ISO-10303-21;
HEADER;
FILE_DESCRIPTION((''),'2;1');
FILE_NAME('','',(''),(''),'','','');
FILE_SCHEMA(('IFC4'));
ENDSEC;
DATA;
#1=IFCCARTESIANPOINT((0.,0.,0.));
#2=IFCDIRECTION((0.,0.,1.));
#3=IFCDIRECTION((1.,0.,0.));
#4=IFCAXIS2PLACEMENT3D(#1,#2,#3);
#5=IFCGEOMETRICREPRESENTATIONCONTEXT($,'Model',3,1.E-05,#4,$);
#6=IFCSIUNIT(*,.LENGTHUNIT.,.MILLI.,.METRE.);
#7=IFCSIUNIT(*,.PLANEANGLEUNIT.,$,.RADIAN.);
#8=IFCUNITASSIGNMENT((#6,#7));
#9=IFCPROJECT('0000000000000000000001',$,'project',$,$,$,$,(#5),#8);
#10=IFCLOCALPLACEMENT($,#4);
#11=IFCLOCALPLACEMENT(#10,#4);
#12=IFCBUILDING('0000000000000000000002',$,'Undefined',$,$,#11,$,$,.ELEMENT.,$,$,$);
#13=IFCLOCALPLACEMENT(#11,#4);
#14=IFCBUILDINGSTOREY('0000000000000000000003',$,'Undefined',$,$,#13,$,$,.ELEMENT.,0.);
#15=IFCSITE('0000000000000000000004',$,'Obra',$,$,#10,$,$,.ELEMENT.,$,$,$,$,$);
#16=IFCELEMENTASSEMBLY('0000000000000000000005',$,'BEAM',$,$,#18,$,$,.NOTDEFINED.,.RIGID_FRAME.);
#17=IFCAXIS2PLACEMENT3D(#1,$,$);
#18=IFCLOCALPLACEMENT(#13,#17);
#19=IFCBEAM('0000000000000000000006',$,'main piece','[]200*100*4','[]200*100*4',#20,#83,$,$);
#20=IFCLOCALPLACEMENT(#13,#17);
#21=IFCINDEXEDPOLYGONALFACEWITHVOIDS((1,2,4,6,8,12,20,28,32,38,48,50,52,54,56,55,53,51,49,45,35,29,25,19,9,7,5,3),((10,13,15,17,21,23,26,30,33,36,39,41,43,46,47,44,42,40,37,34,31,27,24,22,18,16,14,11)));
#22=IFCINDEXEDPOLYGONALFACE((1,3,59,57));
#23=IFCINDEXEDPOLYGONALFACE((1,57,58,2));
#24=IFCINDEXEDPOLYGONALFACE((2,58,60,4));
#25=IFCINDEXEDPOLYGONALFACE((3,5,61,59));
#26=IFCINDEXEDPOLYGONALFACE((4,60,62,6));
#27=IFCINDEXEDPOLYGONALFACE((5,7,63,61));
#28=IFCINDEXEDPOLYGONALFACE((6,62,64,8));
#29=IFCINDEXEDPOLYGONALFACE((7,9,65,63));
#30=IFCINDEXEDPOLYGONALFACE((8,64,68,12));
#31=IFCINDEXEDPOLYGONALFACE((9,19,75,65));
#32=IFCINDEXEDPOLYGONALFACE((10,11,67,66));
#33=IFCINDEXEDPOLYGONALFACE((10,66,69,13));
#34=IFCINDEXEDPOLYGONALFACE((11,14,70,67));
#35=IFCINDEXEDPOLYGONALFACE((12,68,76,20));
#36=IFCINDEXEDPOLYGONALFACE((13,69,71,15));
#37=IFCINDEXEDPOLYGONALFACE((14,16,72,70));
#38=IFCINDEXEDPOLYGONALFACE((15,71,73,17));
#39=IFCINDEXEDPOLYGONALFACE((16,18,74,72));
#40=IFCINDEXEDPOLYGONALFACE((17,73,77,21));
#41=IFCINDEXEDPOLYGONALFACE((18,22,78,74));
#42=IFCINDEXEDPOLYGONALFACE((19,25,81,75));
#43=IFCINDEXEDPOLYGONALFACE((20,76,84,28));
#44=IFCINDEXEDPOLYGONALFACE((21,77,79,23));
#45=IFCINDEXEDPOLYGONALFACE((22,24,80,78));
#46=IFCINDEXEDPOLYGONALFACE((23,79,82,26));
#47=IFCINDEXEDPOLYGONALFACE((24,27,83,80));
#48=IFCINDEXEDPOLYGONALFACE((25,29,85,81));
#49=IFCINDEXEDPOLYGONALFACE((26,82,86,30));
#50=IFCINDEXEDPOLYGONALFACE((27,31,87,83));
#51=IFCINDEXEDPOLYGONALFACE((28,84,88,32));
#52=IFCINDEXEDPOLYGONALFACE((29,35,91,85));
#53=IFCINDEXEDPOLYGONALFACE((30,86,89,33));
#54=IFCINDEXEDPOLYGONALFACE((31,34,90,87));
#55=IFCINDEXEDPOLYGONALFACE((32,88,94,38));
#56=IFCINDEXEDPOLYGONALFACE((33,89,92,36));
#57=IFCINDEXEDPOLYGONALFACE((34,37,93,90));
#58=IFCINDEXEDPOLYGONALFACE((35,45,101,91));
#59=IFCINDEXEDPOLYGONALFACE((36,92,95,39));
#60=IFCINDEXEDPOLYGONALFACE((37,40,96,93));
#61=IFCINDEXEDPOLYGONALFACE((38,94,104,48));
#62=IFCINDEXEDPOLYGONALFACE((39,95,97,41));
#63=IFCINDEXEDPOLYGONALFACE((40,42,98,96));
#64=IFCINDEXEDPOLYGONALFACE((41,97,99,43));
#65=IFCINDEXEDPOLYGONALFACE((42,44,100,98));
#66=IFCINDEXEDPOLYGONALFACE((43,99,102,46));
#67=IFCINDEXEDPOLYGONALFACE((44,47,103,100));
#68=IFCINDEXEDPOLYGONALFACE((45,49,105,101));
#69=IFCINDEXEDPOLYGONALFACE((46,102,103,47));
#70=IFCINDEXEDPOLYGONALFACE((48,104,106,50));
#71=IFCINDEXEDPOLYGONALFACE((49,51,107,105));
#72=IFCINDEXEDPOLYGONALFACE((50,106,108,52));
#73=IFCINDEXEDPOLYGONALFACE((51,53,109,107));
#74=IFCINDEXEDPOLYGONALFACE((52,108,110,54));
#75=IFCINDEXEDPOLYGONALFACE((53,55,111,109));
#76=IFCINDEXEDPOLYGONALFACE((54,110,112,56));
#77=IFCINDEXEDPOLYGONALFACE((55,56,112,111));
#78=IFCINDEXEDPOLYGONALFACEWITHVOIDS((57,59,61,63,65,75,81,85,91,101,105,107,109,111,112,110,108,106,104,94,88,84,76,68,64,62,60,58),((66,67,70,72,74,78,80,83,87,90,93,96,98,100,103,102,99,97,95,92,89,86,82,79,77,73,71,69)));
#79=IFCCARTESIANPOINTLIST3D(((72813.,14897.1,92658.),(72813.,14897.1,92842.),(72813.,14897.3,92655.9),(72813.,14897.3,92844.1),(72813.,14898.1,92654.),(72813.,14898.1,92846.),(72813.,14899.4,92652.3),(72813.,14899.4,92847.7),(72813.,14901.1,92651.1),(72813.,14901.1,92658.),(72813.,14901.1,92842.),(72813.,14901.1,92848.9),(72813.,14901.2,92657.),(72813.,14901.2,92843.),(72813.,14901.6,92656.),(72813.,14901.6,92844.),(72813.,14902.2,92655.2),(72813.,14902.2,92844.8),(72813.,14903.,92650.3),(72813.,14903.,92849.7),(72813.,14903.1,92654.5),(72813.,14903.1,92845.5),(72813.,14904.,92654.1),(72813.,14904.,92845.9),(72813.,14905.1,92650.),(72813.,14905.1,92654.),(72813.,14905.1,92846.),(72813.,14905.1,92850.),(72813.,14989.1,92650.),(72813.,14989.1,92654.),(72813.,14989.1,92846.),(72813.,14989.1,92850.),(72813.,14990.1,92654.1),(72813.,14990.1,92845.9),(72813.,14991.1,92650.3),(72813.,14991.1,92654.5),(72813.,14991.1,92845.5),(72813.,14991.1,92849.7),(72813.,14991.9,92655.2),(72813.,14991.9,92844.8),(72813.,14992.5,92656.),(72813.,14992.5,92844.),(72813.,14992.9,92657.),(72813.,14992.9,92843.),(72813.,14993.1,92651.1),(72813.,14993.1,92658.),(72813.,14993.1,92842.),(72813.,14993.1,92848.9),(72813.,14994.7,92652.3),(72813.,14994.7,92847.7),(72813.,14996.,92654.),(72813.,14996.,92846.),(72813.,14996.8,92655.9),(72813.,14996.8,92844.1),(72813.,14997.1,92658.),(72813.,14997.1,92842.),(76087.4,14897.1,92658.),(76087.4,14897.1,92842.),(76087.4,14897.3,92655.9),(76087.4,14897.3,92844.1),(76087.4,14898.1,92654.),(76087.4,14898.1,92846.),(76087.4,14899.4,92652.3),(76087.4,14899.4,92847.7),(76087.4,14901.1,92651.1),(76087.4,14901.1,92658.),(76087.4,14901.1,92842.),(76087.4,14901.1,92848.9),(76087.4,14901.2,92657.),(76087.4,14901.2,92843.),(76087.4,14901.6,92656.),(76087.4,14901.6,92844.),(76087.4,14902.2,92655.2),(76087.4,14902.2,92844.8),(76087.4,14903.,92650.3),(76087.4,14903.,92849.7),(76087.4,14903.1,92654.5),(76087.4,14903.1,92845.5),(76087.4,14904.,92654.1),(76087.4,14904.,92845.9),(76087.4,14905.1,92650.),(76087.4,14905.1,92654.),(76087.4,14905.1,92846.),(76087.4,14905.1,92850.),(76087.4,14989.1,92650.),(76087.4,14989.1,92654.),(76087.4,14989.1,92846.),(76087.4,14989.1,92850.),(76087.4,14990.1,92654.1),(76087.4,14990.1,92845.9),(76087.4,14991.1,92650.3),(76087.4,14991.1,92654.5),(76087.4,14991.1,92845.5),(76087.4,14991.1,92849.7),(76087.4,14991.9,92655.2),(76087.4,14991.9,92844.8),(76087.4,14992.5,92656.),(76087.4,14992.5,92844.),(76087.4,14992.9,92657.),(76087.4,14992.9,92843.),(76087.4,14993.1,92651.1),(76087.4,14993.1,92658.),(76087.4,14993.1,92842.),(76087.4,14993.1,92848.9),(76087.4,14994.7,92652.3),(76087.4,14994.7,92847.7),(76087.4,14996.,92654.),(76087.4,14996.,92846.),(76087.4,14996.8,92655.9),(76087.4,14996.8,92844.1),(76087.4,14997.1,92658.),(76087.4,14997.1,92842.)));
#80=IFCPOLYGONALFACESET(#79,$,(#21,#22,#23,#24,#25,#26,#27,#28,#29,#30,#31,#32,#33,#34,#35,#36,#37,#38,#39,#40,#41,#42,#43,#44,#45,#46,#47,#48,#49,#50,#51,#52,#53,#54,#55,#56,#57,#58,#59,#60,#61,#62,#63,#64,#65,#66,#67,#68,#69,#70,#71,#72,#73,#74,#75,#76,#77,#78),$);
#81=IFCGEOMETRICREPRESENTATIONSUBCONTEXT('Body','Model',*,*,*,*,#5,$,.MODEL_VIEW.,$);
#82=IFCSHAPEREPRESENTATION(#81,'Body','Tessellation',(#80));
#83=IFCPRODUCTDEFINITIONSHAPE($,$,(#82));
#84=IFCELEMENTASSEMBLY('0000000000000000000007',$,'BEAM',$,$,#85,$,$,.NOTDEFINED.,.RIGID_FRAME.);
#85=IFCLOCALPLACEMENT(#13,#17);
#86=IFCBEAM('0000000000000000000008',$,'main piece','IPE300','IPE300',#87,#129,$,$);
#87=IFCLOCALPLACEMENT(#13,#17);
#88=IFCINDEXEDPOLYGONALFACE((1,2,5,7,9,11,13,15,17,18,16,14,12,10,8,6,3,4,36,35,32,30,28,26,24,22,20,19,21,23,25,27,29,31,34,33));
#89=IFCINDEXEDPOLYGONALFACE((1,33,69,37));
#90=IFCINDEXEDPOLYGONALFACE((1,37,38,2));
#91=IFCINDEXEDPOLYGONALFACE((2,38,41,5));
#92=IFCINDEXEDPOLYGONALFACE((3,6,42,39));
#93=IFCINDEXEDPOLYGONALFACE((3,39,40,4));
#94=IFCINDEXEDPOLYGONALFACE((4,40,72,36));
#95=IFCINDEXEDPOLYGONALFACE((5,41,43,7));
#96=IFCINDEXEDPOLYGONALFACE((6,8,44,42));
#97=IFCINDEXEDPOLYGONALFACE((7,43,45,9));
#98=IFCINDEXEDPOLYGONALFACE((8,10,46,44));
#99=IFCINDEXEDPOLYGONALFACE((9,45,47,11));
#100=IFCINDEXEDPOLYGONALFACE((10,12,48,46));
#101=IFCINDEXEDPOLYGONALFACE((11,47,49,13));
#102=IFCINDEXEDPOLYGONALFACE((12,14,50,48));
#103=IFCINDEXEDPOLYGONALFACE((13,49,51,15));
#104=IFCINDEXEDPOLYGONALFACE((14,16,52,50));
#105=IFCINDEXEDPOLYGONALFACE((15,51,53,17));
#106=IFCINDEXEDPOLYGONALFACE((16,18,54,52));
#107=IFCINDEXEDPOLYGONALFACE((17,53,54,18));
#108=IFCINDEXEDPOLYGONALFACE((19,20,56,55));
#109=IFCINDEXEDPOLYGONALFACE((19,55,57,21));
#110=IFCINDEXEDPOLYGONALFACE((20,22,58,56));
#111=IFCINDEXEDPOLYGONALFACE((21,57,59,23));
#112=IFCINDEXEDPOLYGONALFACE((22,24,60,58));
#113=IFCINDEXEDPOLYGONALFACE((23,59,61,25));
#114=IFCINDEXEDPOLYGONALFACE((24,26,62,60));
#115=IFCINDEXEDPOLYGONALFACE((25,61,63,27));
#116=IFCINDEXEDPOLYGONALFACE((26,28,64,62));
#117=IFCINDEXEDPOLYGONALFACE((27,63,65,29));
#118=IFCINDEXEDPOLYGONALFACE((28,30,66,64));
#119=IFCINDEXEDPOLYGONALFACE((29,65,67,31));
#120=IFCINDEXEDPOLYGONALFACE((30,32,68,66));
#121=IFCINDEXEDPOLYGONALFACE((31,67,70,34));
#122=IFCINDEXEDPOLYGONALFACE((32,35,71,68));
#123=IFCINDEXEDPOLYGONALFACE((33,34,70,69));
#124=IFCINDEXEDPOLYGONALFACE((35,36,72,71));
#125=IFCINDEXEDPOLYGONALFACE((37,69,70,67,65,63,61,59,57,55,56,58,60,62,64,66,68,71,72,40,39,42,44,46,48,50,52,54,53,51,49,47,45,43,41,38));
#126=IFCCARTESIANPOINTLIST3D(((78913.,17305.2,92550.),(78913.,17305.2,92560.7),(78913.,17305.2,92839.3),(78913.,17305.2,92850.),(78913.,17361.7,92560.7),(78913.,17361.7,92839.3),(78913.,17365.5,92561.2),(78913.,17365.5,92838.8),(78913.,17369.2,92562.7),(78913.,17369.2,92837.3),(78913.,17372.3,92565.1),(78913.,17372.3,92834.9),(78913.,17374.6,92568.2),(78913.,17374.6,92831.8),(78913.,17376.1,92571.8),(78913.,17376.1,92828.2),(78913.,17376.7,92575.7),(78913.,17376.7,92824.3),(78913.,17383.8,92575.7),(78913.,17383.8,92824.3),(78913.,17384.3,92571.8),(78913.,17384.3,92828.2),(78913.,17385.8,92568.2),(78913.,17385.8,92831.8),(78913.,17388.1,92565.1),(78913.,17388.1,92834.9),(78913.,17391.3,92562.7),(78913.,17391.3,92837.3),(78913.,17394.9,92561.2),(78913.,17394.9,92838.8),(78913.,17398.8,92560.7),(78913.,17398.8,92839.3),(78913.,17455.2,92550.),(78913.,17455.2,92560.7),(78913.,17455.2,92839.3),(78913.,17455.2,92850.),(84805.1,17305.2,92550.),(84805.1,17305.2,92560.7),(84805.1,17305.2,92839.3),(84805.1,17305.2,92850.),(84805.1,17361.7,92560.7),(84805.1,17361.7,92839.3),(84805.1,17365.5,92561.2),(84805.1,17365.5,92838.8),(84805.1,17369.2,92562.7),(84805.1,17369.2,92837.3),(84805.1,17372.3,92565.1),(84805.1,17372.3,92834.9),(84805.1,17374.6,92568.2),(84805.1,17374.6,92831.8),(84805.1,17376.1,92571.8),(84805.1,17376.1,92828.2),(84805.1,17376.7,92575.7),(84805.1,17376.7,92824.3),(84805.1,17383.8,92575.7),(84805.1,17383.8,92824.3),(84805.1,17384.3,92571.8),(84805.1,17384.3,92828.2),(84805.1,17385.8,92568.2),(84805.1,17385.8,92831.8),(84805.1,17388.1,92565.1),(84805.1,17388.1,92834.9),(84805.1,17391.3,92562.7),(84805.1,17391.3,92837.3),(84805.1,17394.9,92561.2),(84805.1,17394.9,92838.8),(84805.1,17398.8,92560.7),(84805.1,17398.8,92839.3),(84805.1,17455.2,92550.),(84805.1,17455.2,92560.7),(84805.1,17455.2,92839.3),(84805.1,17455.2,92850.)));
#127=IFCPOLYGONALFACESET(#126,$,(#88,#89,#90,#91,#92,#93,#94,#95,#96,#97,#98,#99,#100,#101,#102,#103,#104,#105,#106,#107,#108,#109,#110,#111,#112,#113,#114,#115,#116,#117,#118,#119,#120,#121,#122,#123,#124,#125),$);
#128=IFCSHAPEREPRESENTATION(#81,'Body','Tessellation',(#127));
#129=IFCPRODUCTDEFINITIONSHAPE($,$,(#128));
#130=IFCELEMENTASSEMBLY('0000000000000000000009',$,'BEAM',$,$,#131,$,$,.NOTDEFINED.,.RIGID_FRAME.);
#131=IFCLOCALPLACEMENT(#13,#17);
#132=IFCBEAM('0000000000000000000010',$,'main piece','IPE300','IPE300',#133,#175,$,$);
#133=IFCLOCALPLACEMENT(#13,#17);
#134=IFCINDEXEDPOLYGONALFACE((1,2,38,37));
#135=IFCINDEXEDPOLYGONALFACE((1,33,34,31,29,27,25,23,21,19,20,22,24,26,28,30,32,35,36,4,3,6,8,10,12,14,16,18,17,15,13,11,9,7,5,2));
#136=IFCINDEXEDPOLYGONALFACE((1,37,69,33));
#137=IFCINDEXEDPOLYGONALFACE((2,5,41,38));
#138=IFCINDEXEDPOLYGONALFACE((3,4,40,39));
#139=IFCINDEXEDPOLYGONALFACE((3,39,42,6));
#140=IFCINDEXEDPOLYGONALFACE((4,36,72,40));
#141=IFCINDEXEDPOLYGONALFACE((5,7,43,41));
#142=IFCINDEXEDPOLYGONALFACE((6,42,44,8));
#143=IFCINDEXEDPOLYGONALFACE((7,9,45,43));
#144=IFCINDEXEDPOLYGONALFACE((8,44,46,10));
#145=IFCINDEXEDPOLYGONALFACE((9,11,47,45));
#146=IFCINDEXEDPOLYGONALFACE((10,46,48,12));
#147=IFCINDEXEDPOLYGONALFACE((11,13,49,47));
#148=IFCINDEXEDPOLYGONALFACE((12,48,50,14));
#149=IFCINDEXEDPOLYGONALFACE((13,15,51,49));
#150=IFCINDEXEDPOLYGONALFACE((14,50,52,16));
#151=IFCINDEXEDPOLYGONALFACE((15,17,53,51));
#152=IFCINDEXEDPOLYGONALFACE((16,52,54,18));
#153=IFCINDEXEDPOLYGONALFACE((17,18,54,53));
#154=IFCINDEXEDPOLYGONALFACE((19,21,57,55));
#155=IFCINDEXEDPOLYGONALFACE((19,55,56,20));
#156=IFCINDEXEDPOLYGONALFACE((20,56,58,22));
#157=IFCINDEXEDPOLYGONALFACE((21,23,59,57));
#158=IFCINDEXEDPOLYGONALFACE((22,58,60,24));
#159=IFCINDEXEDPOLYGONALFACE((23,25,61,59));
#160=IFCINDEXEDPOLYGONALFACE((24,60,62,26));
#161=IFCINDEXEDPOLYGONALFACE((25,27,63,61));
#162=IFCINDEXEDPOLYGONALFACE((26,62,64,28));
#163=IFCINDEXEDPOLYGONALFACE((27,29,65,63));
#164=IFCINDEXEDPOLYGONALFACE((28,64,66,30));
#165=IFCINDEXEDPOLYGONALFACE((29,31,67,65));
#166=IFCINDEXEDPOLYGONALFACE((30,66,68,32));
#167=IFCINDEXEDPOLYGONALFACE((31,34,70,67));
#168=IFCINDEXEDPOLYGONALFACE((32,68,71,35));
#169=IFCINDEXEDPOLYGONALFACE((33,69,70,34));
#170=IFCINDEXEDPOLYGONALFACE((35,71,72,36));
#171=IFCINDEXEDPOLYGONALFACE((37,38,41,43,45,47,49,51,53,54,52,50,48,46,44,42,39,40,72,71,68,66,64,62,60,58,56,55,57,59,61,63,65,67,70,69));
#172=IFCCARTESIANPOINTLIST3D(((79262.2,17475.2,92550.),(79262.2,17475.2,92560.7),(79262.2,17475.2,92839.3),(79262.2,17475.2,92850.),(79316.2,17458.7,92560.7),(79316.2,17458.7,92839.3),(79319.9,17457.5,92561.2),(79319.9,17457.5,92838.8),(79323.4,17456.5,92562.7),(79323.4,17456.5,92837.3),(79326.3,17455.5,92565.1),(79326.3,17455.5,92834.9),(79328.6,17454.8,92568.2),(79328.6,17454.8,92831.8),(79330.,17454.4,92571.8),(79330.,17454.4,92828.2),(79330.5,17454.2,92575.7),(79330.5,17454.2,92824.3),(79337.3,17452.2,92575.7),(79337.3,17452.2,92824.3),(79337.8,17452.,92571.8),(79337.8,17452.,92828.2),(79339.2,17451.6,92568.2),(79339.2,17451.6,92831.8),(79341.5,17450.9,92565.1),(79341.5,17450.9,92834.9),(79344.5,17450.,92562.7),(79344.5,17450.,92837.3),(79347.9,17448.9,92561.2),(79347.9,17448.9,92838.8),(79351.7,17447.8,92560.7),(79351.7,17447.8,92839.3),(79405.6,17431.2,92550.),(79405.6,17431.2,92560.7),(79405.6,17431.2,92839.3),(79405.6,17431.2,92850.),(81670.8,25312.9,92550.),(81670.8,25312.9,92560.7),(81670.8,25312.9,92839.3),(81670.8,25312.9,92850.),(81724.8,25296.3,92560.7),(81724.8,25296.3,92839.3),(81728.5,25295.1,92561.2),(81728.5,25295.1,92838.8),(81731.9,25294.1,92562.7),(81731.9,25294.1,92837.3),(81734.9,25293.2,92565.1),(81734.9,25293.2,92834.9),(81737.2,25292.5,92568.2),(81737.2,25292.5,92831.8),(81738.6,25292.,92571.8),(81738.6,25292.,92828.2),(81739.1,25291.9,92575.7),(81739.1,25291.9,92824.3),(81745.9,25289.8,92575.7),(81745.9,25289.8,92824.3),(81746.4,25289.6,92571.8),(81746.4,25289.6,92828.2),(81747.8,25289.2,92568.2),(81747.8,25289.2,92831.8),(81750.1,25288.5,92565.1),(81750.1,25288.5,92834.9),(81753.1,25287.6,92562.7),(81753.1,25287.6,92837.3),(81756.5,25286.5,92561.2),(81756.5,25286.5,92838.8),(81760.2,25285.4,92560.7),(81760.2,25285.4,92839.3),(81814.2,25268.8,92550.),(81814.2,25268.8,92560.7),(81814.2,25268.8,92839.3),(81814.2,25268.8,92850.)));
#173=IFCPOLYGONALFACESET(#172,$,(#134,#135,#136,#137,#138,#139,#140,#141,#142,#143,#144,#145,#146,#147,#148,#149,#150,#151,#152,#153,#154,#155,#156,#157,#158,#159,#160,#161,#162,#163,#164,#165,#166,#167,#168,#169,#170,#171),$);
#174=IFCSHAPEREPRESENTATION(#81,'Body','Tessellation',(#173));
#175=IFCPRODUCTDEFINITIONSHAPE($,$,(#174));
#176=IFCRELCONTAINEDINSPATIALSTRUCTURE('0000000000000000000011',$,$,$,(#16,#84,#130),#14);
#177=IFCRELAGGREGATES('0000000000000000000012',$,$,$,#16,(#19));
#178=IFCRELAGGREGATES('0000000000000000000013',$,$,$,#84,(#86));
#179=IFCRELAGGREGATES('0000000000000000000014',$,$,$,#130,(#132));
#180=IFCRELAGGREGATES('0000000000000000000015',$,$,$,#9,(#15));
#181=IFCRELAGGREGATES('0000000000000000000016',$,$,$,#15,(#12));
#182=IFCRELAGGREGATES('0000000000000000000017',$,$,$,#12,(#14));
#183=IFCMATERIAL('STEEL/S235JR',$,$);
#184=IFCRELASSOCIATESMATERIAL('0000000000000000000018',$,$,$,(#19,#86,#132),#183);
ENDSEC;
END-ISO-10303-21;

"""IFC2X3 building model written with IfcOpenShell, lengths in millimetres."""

from ifc_helpers import new_model, si_unit, frame, origin_with_axes, origin_2d_with_axis, place, context, subcontext, project, spatial, hollow_rectangle, i_section, extrude, material, element, aggregate, save


model = new_model("IFC2X3")

# Units and contexts
model_context = context("Model", 3, precision=1e-05, world=origin_with_axes())
body_context = subcontext(model_context, "Body", "Model", "MODEL_VIEW")
ifc_project = project(units=[si_unit("LENGTHUNIT", "METRE", prefix="MILLI"), si_unit("PLANEANGLEUNIT", "RADIAN")], contexts=[model_context])

# Site, building, storey
site_placement = place(None, origin_with_axes())
site = spatial("IfcSite", under=ifc_project, at=site_placement, Name="Obra", CompositionType="ELEMENT")
building_placement = place(site_placement, origin_with_axes())
building = spatial("IfcBuilding", under=site, at=building_placement, Name="Undefined", CompositionType="ELEMENT")
storey_placement = place(building_placement, origin_with_axes())
storey = spatial("IfcBuildingStorey", under=building, at=storey_placement, Name="Undefined", CompositionType="ELEMENT", Elevation=0.0)

# Element assemblies, beams
ifc_material = material(Name="STEEL/S235JR")
assembly_1_placement = place(storey_placement, origin_with_axes())
assembly_1 = element("IfcElementAssembly", 1, at=assembly_1_placement, inside=storey, Name="BEAM", AssemblyPlace="NOTDEFINED", PredefinedType="RIGID_FRAME")
beam_1_placement = place(assembly_1_placement, frame((72813.0, 14947.1, 92750.0), z_axis=(0.0, 0.0, 1.0), x_axis=(1.0, 0.0, 0.0)))
beam_1 = element("IfcBeam", 2, at=beam_1_placement, material=ifc_material, Name="main piece", Description="[]200*100*4", ObjectType="[]200*100*4", context=body_context, shape_type="SweptSolid", body=[
    extrude(hollow_rectangle(XDim=100.0, YDim=200.0, WallThickness=4.0, InnerFilletRadius=4.0, OuterFilletRadius=8.0, at=origin_2d_with_axis()), frame((3274.4, 0.0, 0.0), z_axis=(-1.0, 0.0, 0.0), x_axis=(0.0, -1.0, 0.0)), (0.0, 0.0, 1.0), 3274.4),
])
aggregate(assembly_1, [beam_1])
assembly_2_placement = place(storey_placement, origin_with_axes())
assembly_2 = element("IfcElementAssembly", 3, at=assembly_2_placement, inside=storey, Name="BEAM", AssemblyPlace="NOTDEFINED", PredefinedType="RIGID_FRAME")
beam_2_placement = place(assembly_2_placement, frame((78913.0, 17380.2, 92700.0), z_axis=(0.0, 0.0, 1.0), x_axis=(1.0, 0.0, 0.0)))
beam_2 = element("IfcBeam", 4, at=beam_2_placement, material=ifc_material, Name="main piece", Description="IPE300", ObjectType="IPE300", context=body_context, shape_type="SweptSolid", body=[
    extrude(i_section(OverallWidth=150.0, OverallDepth=300.0, WebThickness=7.1, FlangeThickness=10.7, FilletRadius=15.0, at=origin_2d_with_axis()), frame((5892.1, 0.0, 0.0), z_axis=(-1.0, 0.0, 0.0), x_axis=(0.0, -1.0, 0.0)), (0.0, 0.0, 1.0), 5892.1),
])
aggregate(assembly_2, [beam_2])
assembly_3_placement = place(storey_placement, origin_with_axes())
assembly_3 = element("IfcElementAssembly", 5, at=assembly_3_placement, inside=storey, Name="BEAM", AssemblyPlace="NOTDEFINED", PredefinedType="RIGID_FRAME")
beam_3_placement = place(assembly_3_placement, frame((79333.9, 17453.2, 92700.0), z_axis=(0.0, 0.0, 1.0), x_axis=(0.293752, 0.955882, 0.0)))
beam_3 = element("IfcBeam", 6, at=beam_3_placement, material=ifc_material, Name="main piece", Description="IPE300", ObjectType="IPE300", context=body_context, shape_type="SweptSolid", body=[
    extrude(i_section(OverallWidth=150.0, OverallDepth=300.0, WebThickness=7.1, FlangeThickness=10.7, FilletRadius=15.0, at=origin_2d_with_axis()), frame((8199.4, 0.0, 0.0), z_axis=(-1.0, 0.0, 0.0), x_axis=(0.0, -1.0, 0.0)), (0.0, 0.0, 1.0), 8199.4),
])
aggregate(assembly_3, [beam_3])

save(model, "model.ifc")
